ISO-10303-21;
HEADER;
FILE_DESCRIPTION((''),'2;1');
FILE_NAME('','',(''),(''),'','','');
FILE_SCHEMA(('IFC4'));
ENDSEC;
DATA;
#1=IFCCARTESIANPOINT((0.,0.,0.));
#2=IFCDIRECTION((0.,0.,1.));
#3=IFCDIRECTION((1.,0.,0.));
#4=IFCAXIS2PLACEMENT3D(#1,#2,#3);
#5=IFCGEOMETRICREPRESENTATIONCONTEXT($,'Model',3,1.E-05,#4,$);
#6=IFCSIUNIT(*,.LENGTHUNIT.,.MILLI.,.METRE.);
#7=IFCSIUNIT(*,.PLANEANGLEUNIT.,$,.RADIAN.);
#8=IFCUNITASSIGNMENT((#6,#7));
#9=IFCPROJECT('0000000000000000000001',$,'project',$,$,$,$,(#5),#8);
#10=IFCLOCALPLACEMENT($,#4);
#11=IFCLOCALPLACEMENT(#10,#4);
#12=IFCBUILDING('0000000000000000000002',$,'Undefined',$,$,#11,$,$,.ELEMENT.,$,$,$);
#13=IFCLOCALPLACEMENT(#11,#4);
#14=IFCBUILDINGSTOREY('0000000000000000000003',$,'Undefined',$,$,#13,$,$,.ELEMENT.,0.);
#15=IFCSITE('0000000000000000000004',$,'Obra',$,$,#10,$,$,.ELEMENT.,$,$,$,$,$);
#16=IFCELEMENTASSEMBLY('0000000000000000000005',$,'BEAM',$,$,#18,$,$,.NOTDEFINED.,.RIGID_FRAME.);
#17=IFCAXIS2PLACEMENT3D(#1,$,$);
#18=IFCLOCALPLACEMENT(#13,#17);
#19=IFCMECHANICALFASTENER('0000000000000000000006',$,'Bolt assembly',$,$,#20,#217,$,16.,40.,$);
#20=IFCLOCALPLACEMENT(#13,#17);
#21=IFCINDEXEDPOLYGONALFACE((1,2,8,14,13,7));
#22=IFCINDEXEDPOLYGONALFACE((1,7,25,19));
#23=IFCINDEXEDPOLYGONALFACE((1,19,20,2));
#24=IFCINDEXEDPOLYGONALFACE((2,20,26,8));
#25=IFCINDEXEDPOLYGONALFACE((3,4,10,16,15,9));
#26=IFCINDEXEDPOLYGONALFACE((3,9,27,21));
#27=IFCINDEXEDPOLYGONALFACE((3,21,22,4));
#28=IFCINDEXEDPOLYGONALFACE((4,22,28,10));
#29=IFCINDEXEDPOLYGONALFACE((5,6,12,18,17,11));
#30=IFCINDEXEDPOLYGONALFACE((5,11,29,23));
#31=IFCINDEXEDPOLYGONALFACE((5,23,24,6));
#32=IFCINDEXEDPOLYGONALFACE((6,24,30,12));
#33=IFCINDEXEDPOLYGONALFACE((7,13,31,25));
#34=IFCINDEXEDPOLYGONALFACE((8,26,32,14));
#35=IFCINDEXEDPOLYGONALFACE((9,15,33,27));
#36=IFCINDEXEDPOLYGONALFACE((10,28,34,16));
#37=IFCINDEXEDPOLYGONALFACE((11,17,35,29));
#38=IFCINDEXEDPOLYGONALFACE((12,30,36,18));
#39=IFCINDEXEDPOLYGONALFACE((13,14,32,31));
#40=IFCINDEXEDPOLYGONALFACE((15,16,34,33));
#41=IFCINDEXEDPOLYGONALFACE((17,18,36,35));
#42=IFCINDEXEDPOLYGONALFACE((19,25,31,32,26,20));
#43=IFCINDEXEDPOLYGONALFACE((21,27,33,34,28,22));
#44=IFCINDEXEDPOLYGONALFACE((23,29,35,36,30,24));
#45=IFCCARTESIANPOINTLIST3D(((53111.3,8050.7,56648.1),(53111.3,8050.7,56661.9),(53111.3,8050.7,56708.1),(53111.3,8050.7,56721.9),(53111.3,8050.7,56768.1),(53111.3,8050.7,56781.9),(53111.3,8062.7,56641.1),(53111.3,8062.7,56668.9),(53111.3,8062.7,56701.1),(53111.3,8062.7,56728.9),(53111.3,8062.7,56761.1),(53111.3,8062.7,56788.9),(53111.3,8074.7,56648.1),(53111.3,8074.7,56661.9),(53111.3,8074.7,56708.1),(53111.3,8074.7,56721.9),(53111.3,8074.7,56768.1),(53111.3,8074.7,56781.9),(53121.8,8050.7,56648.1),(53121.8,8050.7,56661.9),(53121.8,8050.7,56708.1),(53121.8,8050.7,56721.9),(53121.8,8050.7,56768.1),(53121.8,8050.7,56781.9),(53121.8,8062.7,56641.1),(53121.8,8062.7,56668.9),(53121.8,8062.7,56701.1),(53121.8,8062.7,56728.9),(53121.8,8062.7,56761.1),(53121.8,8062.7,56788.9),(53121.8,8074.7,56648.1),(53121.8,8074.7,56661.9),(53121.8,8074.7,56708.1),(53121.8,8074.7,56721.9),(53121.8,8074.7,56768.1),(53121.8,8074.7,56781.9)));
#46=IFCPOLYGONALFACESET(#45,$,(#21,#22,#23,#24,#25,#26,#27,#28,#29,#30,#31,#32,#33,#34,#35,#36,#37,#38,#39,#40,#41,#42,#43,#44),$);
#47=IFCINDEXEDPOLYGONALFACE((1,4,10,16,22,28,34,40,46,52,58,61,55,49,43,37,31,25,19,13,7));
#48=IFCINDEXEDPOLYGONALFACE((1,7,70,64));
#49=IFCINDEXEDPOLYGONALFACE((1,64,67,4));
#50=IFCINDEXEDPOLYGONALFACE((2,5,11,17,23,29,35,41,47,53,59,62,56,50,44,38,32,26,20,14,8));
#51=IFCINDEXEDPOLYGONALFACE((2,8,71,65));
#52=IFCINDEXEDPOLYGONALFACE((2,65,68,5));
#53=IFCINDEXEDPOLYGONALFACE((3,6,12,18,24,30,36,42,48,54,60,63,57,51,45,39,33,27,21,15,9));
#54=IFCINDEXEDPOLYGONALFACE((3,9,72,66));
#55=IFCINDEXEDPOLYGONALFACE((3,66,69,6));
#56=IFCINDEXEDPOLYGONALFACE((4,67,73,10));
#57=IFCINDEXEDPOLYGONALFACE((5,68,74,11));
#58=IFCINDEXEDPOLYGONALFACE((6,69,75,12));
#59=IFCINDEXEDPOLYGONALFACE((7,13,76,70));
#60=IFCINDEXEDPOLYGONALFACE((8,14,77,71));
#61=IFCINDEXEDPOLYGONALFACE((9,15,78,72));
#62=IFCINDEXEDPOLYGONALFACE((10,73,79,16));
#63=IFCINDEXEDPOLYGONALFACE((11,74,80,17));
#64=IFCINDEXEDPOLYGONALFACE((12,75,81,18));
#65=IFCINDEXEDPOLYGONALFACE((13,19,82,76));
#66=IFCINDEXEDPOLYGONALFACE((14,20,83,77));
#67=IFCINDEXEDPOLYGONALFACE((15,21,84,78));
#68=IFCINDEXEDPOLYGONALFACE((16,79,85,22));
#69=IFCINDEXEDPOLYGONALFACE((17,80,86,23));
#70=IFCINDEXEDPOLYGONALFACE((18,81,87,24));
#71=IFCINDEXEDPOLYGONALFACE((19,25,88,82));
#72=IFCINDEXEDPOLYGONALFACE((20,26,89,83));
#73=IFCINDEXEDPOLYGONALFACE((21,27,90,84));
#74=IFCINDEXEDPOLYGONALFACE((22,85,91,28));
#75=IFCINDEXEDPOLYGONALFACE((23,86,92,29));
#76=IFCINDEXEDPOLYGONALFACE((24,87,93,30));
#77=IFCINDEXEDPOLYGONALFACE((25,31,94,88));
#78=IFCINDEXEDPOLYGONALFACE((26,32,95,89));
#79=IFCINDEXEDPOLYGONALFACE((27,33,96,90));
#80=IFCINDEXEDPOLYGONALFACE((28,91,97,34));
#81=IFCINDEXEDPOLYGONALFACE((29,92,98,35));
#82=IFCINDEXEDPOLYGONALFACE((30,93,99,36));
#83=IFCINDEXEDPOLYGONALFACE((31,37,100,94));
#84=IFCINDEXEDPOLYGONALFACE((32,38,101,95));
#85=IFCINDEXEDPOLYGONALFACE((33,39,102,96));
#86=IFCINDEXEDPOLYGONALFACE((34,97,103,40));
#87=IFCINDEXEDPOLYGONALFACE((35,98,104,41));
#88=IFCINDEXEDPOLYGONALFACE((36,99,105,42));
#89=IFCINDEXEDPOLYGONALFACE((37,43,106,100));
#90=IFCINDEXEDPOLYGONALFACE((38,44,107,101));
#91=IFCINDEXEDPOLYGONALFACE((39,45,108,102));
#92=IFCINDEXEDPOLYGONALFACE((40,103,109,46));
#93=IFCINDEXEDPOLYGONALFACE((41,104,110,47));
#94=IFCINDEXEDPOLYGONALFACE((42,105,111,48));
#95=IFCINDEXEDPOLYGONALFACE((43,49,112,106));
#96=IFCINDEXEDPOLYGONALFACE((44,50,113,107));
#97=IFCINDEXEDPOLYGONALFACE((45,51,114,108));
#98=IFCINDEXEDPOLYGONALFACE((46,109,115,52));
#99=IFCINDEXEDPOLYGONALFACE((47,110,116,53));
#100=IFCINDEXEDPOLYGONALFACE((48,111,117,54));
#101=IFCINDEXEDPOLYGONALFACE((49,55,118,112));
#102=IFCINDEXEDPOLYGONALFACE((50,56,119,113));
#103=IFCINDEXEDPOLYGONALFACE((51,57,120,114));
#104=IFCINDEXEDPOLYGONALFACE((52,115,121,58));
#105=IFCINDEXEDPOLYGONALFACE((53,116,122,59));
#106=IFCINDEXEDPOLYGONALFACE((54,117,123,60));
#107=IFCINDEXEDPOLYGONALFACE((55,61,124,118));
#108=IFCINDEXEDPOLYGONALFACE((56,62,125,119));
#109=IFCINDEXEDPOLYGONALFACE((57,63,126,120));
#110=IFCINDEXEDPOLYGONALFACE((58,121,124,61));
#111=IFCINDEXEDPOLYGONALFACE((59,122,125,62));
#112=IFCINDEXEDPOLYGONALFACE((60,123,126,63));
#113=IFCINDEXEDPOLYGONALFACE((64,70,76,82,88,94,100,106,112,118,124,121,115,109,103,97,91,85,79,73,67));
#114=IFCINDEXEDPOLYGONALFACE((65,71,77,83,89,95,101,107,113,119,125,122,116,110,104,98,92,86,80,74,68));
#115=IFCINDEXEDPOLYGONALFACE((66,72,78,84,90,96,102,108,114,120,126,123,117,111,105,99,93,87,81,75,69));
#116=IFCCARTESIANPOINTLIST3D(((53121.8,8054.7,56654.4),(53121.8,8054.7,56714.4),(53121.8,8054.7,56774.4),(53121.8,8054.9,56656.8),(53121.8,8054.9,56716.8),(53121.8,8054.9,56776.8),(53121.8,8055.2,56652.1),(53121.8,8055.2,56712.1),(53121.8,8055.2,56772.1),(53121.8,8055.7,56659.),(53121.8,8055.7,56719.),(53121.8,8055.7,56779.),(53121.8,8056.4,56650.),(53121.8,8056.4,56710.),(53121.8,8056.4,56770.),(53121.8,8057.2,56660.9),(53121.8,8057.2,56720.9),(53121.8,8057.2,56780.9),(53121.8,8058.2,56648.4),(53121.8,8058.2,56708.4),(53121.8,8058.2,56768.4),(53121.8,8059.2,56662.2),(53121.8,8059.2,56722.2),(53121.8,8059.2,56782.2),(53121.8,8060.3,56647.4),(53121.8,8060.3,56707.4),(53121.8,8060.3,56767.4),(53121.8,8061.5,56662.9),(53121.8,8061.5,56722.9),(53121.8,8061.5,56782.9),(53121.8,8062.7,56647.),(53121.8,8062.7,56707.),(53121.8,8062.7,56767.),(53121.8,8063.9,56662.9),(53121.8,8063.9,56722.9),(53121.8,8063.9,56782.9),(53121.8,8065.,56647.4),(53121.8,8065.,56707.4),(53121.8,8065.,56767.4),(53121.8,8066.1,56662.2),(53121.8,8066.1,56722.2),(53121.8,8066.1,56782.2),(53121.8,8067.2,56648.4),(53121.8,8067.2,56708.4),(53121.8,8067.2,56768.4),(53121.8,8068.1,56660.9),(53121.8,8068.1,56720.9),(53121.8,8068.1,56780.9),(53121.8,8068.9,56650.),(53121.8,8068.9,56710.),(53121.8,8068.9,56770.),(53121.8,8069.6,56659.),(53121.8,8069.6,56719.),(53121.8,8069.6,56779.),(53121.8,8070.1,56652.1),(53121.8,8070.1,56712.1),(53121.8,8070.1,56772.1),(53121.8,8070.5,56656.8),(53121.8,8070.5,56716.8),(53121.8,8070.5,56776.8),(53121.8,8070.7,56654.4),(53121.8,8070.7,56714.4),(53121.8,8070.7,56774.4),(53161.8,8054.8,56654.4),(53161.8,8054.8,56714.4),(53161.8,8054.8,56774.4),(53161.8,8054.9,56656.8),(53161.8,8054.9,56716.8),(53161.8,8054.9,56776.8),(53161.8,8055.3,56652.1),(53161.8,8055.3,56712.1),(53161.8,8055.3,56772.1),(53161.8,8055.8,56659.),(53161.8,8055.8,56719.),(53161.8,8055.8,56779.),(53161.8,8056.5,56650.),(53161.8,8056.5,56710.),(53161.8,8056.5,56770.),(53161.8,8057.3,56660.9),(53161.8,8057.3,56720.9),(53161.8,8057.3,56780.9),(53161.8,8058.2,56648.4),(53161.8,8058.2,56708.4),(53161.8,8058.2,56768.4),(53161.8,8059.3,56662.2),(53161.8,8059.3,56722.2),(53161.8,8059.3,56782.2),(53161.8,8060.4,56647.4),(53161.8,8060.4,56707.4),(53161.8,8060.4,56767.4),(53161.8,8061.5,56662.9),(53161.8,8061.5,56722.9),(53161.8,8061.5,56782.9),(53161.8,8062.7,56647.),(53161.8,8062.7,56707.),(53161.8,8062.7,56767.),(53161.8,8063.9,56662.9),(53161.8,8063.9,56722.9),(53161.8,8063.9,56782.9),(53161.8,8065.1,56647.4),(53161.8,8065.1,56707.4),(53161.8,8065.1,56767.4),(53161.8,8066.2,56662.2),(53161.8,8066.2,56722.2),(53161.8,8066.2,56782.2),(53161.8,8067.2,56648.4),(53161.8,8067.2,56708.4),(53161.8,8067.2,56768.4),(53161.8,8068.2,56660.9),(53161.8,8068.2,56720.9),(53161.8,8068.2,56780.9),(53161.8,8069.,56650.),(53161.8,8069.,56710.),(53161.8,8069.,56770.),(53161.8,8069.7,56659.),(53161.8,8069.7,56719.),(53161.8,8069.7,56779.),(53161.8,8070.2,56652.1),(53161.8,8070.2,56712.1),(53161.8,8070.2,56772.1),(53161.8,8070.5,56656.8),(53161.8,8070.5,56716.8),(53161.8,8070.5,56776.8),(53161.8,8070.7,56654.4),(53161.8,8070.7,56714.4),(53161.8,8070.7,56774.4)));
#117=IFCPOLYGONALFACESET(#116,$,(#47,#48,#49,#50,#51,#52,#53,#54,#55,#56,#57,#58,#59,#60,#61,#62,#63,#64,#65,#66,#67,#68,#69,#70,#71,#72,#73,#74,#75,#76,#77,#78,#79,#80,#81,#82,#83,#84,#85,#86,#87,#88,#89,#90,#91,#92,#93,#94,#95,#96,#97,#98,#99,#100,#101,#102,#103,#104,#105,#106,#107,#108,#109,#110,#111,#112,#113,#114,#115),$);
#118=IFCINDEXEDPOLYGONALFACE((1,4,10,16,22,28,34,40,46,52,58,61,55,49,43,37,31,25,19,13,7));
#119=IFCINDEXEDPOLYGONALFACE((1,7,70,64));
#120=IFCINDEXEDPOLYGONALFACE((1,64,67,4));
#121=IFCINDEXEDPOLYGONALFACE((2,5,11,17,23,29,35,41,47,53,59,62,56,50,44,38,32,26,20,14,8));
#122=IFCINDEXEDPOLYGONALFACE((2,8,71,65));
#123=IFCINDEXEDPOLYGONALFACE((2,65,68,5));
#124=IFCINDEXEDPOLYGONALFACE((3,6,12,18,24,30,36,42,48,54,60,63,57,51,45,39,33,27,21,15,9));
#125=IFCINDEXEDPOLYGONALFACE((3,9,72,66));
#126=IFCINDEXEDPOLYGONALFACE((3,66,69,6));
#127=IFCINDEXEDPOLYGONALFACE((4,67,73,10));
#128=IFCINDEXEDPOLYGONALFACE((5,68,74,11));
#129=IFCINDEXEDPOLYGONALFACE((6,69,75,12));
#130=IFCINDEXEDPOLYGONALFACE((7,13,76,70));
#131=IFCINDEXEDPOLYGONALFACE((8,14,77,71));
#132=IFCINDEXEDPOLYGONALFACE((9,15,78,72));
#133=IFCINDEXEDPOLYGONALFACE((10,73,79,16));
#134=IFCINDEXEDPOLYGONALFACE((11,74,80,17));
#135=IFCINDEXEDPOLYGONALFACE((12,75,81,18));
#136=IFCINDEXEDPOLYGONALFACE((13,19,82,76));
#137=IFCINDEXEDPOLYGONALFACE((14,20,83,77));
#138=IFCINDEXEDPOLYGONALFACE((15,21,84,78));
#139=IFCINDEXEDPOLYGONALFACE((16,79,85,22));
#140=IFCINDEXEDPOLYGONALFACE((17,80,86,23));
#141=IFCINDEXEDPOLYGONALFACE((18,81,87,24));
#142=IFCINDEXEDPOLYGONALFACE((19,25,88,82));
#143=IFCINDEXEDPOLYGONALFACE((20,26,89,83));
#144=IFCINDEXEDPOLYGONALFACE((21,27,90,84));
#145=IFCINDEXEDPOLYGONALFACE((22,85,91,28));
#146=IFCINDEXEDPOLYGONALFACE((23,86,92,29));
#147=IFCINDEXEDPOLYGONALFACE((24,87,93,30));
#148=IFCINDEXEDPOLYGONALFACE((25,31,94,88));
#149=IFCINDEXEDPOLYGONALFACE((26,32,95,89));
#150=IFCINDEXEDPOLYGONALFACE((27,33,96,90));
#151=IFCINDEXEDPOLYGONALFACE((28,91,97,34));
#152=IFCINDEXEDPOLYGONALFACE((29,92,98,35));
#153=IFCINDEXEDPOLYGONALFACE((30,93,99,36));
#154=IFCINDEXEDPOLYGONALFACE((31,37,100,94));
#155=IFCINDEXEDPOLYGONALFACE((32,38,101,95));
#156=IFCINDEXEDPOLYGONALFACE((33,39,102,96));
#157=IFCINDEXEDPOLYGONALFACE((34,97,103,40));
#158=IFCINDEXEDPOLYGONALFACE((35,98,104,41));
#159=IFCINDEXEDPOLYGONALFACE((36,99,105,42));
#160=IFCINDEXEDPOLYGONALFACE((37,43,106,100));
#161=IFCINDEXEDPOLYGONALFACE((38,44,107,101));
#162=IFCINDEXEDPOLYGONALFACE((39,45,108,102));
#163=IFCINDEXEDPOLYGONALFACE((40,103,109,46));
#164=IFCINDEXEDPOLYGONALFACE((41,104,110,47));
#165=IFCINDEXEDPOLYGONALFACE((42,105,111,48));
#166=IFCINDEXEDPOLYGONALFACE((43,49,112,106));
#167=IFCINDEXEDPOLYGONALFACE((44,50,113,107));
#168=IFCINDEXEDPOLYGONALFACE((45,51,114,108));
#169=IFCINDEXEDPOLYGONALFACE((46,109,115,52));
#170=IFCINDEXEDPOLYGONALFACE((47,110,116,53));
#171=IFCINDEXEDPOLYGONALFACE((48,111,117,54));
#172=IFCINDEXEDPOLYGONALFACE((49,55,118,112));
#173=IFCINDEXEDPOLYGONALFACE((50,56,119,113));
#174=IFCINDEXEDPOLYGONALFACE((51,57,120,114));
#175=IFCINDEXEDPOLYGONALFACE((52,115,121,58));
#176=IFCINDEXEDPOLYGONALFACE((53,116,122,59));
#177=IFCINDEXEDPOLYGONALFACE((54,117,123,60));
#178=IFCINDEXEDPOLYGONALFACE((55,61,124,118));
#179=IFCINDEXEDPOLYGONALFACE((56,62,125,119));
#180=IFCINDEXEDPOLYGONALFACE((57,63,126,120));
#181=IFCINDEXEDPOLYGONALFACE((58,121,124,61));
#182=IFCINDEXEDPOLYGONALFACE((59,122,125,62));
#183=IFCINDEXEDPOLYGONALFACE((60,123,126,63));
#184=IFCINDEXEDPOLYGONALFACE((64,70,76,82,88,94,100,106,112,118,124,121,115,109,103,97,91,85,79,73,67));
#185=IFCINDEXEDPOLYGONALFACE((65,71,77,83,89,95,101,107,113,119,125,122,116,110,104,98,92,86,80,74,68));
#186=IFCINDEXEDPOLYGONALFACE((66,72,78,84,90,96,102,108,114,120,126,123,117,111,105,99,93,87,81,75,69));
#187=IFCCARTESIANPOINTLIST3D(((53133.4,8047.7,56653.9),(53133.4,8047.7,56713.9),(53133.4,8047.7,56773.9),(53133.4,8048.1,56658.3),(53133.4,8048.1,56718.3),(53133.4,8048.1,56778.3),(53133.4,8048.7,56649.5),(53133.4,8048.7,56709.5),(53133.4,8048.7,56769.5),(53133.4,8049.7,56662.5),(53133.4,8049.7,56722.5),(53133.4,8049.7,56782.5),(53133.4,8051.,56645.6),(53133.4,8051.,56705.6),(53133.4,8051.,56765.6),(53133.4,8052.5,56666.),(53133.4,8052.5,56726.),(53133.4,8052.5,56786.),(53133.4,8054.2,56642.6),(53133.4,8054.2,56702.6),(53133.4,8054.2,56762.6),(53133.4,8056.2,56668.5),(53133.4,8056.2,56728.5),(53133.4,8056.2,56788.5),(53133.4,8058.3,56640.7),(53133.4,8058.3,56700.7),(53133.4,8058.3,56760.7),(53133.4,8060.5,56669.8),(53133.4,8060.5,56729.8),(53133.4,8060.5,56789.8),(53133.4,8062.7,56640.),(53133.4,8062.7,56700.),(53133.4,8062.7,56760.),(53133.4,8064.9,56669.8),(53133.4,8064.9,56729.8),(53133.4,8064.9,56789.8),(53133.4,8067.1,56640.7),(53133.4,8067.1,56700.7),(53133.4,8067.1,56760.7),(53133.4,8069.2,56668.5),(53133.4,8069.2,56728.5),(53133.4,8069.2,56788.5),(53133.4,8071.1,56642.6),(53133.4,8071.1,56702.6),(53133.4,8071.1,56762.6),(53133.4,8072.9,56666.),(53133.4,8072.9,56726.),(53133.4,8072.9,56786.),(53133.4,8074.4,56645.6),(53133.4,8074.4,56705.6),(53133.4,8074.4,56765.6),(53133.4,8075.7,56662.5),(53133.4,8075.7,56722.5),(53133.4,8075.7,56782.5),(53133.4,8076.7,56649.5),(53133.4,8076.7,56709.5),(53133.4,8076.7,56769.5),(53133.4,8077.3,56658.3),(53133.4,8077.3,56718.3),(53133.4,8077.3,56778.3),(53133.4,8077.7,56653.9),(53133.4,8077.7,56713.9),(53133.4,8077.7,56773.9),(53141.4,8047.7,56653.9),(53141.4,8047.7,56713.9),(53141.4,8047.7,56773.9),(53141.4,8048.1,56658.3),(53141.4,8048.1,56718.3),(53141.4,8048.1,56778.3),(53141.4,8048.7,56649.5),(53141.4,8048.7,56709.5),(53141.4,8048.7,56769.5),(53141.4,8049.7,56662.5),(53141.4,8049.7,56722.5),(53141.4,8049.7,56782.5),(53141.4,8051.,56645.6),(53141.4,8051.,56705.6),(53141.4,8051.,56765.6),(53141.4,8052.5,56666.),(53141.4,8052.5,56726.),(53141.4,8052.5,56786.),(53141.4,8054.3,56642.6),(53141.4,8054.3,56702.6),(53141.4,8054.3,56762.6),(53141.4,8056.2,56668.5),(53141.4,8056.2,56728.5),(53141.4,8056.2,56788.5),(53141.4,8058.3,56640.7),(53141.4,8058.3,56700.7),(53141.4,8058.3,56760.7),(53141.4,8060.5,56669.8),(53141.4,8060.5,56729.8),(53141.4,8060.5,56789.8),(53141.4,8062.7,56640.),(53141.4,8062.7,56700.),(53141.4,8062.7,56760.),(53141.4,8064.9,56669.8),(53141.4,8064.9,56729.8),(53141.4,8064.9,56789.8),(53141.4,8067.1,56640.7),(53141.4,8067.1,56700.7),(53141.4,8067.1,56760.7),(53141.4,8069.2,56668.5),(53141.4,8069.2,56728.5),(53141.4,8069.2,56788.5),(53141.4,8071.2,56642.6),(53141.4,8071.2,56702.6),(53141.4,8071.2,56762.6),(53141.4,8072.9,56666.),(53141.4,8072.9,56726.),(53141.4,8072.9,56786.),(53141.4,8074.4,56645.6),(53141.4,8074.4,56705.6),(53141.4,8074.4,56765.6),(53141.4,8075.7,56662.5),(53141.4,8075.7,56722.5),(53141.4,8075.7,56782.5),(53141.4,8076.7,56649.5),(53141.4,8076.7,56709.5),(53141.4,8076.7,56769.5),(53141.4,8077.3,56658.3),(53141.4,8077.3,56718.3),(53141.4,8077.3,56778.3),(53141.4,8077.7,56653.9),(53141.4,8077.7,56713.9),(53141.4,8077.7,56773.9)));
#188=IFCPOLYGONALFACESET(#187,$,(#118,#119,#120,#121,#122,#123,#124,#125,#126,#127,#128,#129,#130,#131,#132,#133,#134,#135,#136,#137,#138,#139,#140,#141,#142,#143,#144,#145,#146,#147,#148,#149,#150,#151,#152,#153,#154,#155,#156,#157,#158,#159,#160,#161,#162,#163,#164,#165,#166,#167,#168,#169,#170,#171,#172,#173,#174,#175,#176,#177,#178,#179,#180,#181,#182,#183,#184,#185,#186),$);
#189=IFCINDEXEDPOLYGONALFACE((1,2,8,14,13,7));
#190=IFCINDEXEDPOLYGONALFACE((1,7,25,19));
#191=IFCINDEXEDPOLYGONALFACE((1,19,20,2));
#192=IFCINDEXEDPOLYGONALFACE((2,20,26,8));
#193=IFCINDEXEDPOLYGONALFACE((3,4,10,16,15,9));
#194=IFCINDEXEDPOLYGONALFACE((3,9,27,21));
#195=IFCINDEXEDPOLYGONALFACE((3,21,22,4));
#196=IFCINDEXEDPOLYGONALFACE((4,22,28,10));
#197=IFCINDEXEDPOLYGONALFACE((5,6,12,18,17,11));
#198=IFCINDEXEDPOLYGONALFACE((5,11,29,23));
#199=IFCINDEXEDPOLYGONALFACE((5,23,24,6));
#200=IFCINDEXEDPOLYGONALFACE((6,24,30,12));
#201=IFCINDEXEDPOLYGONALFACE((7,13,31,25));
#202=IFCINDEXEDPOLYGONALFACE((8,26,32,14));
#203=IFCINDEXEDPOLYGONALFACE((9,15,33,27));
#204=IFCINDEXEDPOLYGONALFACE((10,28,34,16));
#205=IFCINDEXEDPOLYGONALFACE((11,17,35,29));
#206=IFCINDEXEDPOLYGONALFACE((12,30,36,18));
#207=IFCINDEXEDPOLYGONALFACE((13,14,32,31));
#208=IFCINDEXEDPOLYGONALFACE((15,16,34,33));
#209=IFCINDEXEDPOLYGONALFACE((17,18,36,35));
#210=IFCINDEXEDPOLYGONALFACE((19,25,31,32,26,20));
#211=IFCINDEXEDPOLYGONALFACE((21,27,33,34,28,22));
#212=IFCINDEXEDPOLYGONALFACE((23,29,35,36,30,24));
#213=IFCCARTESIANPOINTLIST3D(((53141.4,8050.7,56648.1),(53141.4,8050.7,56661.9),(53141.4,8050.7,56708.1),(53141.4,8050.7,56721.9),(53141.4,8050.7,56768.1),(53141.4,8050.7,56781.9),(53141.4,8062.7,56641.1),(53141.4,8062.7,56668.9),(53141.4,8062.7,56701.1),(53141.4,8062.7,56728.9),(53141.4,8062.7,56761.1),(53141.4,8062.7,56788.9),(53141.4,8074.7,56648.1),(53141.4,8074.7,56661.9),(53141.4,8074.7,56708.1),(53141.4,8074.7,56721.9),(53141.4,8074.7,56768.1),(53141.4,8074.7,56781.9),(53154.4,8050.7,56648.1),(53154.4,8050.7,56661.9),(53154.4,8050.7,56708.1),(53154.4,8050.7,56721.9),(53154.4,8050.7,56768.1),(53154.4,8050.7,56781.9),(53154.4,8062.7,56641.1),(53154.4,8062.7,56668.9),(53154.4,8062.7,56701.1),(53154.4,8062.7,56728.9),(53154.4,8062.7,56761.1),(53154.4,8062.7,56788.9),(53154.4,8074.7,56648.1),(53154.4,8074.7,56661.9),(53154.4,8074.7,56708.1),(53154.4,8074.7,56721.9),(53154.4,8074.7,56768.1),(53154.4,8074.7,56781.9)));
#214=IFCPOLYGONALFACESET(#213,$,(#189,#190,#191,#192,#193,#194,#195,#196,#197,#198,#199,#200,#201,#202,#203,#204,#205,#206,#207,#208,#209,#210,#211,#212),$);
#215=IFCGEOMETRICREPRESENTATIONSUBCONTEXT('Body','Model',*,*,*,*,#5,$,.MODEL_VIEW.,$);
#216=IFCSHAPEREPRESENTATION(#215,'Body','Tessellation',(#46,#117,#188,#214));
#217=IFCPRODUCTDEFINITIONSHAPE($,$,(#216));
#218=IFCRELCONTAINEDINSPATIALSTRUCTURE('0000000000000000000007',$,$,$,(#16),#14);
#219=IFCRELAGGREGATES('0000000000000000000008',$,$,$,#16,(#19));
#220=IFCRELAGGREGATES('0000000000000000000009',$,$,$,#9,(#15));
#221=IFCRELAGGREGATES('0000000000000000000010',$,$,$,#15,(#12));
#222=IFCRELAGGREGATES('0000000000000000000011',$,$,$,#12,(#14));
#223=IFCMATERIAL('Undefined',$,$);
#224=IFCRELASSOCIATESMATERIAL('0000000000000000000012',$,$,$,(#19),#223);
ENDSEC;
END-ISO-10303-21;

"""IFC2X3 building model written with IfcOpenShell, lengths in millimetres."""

from ifc_helpers import new_model, si_unit, frame, origin_with_axes, origin_2d_with_axis, place, context, subcontext, project, spatial, polyline, circle, outline, extrude, source, transform, mapped, material, element, aggregate, save


model = new_model("IFC2X3")

# Units and contexts
model_context = context("Model", 3, precision=1e-05, world=origin_with_axes())
body_context = subcontext(model_context, "Body", "Model", "MODEL_VIEW")
ifc_project = project(units=[si_unit("LENGTHUNIT", "METRE", prefix="MILLI"), si_unit("PLANEANGLEUNIT", "RADIAN")], contexts=[model_context])

# Site, building, storey
site_placement = place(None, origin_with_axes())
site = spatial("IfcSite", under=ifc_project, at=site_placement, Name="Obra", CompositionType="ELEMENT")
building_placement = place(site_placement, origin_with_axes())
building = spatial("IfcBuilding", under=site, at=building_placement, Name="Undefined", CompositionType="ELEMENT")
storey_placement = place(building_placement, origin_with_axes())
storey = spatial("IfcBuildingStorey", under=building, at=storey_placement, Name="Undefined", CompositionType="ELEMENT", Elevation=0.0)

# Element assembly, mechanical fastener
assembly_1_placement = place(storey_placement, origin_with_axes())
assembly_1 = element("IfcElementAssembly", 1, at=assembly_1_placement, inside=storey, Name="BEAM", AssemblyPlace="NOTDEFINED", PredefinedType="RIGID_FRAME")
ifc_material_1 = material(Name="Undefined")
shared_shape_1 = source(origin_with_axes(), body_context, "Body", "SweptSolid", [
    extrude(outline(polyline([(13.9, 0.0), (6.9, 12.0), (-6.9, 12.0), (-13.9, 0.0), (-6.9, -12.0), (6.9, -12.0), (13.9, 0.0)])), frame((0.0, -19.7, 0.0), z_axis=(0.0, 1.0, 0.0), x_axis=(1.0, 0.0, 0.0)), (0.0, 0.0, 1.0), 10.6),
    extrude(circle(Radius=8.0, at=origin_2d_with_axis()), frame((0.0, -9.1, 0.0), z_axis=(0.0, 1.0, 0.0), x_axis=(1.0, 0.0, 0.0)), (0.0, 0.0, 1.0), 40.0),
    extrude(circle(Radius=15.0, at=origin_2d_with_axis()), frame((0.0, 2.5, 0.0), z_axis=(0.0, 1.0, 0.0), x_axis=(1.0, 0.0, 0.0)), (0.0, 0.0, 1.0), 8.0),
    extrude(outline(polyline([(13.9, 0.0), (6.9, 12.0), (-6.9, 12.0), (-13.9, 0.0), (-6.9, -12.0), (6.9, -12.0), (13.9, 0.0)])), frame((0.0, 10.5, 0.0), z_axis=(0.0, 1.0, 0.0), x_axis=(1.0, 0.0, 0.0)), (0.0, 0.0, 1.0), 13.0),
])
mechanical_fastener_1_placement = place(assembly_1_placement, frame((53130.9, 8112.7, 56835.0), z_axis=(0.001508, -0.999999, 0.0), x_axis=(0.0, 0.0, -1.0)))
mechanical_fastener_1 = element("IfcMechanicalFastener", 2, at=mechanical_fastener_1_placement, material=ifc_material_1, Name="Bolt assembly", NominalDiameter=16.0, NominalLength=40.0, context=body_context, shape_type="MappedRepresentation", body=[
    mapped(shared_shape_1, transform((60.0, 0.0, 50.0))),
    mapped(shared_shape_1, transform((120.0, 0.0, 50.0))),
    mapped(shared_shape_1, transform((180.0, 0.0, 50.0))),
])
aggregate(assembly_1, [mechanical_fastener_1])

save(model, "model.ifc")
